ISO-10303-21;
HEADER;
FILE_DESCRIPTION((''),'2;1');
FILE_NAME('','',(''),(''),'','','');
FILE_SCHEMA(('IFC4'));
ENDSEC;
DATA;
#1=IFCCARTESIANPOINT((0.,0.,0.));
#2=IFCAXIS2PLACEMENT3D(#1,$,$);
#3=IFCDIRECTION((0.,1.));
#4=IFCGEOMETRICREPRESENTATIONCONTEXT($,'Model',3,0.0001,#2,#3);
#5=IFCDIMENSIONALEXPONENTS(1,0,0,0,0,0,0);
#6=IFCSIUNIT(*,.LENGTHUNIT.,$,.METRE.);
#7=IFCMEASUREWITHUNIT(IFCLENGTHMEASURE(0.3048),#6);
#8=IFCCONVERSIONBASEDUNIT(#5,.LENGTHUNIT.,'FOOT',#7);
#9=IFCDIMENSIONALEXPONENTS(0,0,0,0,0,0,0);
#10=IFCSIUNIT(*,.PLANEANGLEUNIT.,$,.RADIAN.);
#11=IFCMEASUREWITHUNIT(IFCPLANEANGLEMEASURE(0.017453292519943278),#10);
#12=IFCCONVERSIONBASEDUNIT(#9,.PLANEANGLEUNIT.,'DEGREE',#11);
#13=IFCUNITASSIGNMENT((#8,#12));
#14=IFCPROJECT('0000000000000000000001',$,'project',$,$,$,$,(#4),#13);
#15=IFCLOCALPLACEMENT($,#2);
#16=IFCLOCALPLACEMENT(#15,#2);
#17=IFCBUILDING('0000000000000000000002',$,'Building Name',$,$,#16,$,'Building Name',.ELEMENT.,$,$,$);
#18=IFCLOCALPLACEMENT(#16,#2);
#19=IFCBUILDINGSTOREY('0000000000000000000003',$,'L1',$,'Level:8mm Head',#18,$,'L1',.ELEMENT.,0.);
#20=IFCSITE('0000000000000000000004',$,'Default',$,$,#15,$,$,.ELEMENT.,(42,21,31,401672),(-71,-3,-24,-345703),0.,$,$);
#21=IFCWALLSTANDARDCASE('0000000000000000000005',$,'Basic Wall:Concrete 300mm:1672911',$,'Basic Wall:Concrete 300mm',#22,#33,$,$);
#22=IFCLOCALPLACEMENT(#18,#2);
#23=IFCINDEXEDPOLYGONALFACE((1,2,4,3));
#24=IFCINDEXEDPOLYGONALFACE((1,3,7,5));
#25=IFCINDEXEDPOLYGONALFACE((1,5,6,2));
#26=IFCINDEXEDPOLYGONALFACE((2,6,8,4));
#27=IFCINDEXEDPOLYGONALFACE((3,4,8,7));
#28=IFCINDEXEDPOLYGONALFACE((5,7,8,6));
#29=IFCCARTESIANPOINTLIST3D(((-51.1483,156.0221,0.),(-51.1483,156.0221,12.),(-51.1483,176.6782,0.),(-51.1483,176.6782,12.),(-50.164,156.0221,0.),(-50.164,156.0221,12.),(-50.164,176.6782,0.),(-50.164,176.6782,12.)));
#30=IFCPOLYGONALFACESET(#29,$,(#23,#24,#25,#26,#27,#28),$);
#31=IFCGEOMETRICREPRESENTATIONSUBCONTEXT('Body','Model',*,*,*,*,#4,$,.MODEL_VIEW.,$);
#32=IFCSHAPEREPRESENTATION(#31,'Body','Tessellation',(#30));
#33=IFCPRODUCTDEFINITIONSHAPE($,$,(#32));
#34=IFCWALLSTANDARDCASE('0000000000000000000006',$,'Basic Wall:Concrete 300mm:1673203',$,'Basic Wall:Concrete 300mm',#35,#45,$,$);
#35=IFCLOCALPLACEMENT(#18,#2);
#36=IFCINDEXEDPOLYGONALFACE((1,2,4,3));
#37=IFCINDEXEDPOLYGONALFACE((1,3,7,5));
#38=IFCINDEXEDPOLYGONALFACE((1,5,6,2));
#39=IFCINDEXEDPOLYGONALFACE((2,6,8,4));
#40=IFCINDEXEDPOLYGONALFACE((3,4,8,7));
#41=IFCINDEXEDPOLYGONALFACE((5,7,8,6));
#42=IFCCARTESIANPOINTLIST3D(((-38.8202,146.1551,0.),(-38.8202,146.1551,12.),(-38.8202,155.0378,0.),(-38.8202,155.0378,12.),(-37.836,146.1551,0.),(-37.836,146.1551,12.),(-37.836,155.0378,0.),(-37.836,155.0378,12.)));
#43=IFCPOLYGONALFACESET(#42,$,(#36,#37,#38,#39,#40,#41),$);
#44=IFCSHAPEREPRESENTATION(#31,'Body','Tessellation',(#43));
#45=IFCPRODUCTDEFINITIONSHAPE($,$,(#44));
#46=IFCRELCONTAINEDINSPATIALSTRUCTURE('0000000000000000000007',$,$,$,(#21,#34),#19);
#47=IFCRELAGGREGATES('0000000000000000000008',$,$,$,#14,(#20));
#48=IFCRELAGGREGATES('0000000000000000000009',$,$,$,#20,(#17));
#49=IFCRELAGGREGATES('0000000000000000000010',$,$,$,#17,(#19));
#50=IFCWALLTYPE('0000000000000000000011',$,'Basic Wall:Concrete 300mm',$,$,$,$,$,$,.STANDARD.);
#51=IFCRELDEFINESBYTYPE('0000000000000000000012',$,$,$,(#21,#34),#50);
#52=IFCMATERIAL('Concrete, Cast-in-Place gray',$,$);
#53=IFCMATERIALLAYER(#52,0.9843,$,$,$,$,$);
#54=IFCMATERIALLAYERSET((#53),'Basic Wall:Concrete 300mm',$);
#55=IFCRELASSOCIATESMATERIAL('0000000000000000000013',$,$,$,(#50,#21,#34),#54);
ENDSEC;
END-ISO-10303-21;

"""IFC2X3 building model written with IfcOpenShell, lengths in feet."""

from ifc_helpers import new_model, entity, si_unit, converted_unit, direction, frame, frame_2d, origin, place, context, subcontext, project, spatial, rectangle, extrude, material, layer, layer_set, layer_usage, type_object, element, save


model = new_model("IFC2X3")

# Units and contexts
model_context = context("Model", 3, precision=0.0001, world=origin(), true_north=direction((0.0, 1.0)))
body_context = subcontext(model_context, "Body", "Model", "MODEL_VIEW")
ifc_project = project(units=[converted_unit("LENGTHUNIT", "FOOT", entity("IfcLengthMeasure", 0.3048), si_unit("LENGTHUNIT", "METRE"), dimensions=[1, 0, 0, 0, 0, 0, 0]), converted_unit("PLANEANGLEUNIT", "DEGREE", entity("IfcPlaneAngleMeasure", 0.017453292519943278), si_unit("PLANEANGLEUNIT", "RADIAN"), dimensions=[0, 0, 0, 0, 0, 0, 0])], contexts=[model_context])

# Site, building, storey
site_placement = place(None, origin())
site = spatial("IfcSite", under=ifc_project, at=site_placement, Name="Default", CompositionType="ELEMENT", RefLatitude=(42, 21, 31, 401672), RefLongitude=(-71, -3, -24, -345703), RefElevation=0.0)
building_placement = place(site_placement, origin())
building = spatial("IfcBuilding", under=site, at=building_placement, Name="Building Name", LongName="Building Name", CompositionType="ELEMENT")
storey_placement = place(building_placement, origin())
storey = spatial("IfcBuildingStorey", under=building, at=storey_placement, Name="L1", ObjectType="Level:8mm Head", LongName="L1", CompositionType="ELEMENT", Elevation=0.0)

# Shared definitions
ifc_material_1 = material(Name="Concrete, Cast-in-Place gray")
ifc_layer = layer(ifc_material_1, 0.9843)
ifc_layer_set = layer_set([ifc_layer], Name="Basic Wall:Concrete 300mm")
wall_type = type_object("IfcWallType", Name="Basic Wall:Concrete 300mm", PredefinedType="STANDARD", material=ifc_layer_set)

# Walls
ifc_layer_usage_1 = layer_usage(ifc_layer_set, "AXIS2", "POSITIVE", -0.4921)
wall_1_placement = place(storey_placement, frame((-50.6562, 176.6782, 0.0), z_axis=(0.0, 0.0, 1.0), x_axis=(0.0, -1.0, 0.0)))
element("IfcWallStandardCase", 1, at=wall_1_placement, inside=storey, type_object=wall_type, material=ifc_layer_usage_1, Name="Basic Wall:Concrete 300mm:1672911", ObjectType="Basic Wall:Concrete 300mm", context=body_context, shape_type="SweptSolid", body=[
    extrude(rectangle(XDim=20.6562, YDim=0.9843, at=frame_2d((10.3281, 0.0), x_axis=(-1.0, 0.0))), origin(), (0.0, 0.0, 1.0), 12.0),
])
ifc_layer_usage_2 = layer_usage(ifc_layer_set, "AXIS2", "NEGATIVE", 0.4921)
wall_2_placement = place(storey_placement, frame((-38.3281, 155.0378, 0.0), z_axis=(0.0, 0.0, 1.0), x_axis=(0.0, -1.0, 0.0)))
element("IfcWallStandardCase", 2, at=wall_2_placement, inside=storey, type_object=wall_type, material=ifc_layer_usage_2, Name="Basic Wall:Concrete 300mm:1673203", ObjectType="Basic Wall:Concrete 300mm", context=body_context, shape_type="SweptSolid", body=[
    extrude(rectangle(XDim=8.8827, YDim=0.9843, at=frame_2d((4.4414, 0.0), x_axis=(-1.0, 0.0))), origin(), (0.0, 0.0, 1.0), 12.0),
])

save(model, "model.ifc")
